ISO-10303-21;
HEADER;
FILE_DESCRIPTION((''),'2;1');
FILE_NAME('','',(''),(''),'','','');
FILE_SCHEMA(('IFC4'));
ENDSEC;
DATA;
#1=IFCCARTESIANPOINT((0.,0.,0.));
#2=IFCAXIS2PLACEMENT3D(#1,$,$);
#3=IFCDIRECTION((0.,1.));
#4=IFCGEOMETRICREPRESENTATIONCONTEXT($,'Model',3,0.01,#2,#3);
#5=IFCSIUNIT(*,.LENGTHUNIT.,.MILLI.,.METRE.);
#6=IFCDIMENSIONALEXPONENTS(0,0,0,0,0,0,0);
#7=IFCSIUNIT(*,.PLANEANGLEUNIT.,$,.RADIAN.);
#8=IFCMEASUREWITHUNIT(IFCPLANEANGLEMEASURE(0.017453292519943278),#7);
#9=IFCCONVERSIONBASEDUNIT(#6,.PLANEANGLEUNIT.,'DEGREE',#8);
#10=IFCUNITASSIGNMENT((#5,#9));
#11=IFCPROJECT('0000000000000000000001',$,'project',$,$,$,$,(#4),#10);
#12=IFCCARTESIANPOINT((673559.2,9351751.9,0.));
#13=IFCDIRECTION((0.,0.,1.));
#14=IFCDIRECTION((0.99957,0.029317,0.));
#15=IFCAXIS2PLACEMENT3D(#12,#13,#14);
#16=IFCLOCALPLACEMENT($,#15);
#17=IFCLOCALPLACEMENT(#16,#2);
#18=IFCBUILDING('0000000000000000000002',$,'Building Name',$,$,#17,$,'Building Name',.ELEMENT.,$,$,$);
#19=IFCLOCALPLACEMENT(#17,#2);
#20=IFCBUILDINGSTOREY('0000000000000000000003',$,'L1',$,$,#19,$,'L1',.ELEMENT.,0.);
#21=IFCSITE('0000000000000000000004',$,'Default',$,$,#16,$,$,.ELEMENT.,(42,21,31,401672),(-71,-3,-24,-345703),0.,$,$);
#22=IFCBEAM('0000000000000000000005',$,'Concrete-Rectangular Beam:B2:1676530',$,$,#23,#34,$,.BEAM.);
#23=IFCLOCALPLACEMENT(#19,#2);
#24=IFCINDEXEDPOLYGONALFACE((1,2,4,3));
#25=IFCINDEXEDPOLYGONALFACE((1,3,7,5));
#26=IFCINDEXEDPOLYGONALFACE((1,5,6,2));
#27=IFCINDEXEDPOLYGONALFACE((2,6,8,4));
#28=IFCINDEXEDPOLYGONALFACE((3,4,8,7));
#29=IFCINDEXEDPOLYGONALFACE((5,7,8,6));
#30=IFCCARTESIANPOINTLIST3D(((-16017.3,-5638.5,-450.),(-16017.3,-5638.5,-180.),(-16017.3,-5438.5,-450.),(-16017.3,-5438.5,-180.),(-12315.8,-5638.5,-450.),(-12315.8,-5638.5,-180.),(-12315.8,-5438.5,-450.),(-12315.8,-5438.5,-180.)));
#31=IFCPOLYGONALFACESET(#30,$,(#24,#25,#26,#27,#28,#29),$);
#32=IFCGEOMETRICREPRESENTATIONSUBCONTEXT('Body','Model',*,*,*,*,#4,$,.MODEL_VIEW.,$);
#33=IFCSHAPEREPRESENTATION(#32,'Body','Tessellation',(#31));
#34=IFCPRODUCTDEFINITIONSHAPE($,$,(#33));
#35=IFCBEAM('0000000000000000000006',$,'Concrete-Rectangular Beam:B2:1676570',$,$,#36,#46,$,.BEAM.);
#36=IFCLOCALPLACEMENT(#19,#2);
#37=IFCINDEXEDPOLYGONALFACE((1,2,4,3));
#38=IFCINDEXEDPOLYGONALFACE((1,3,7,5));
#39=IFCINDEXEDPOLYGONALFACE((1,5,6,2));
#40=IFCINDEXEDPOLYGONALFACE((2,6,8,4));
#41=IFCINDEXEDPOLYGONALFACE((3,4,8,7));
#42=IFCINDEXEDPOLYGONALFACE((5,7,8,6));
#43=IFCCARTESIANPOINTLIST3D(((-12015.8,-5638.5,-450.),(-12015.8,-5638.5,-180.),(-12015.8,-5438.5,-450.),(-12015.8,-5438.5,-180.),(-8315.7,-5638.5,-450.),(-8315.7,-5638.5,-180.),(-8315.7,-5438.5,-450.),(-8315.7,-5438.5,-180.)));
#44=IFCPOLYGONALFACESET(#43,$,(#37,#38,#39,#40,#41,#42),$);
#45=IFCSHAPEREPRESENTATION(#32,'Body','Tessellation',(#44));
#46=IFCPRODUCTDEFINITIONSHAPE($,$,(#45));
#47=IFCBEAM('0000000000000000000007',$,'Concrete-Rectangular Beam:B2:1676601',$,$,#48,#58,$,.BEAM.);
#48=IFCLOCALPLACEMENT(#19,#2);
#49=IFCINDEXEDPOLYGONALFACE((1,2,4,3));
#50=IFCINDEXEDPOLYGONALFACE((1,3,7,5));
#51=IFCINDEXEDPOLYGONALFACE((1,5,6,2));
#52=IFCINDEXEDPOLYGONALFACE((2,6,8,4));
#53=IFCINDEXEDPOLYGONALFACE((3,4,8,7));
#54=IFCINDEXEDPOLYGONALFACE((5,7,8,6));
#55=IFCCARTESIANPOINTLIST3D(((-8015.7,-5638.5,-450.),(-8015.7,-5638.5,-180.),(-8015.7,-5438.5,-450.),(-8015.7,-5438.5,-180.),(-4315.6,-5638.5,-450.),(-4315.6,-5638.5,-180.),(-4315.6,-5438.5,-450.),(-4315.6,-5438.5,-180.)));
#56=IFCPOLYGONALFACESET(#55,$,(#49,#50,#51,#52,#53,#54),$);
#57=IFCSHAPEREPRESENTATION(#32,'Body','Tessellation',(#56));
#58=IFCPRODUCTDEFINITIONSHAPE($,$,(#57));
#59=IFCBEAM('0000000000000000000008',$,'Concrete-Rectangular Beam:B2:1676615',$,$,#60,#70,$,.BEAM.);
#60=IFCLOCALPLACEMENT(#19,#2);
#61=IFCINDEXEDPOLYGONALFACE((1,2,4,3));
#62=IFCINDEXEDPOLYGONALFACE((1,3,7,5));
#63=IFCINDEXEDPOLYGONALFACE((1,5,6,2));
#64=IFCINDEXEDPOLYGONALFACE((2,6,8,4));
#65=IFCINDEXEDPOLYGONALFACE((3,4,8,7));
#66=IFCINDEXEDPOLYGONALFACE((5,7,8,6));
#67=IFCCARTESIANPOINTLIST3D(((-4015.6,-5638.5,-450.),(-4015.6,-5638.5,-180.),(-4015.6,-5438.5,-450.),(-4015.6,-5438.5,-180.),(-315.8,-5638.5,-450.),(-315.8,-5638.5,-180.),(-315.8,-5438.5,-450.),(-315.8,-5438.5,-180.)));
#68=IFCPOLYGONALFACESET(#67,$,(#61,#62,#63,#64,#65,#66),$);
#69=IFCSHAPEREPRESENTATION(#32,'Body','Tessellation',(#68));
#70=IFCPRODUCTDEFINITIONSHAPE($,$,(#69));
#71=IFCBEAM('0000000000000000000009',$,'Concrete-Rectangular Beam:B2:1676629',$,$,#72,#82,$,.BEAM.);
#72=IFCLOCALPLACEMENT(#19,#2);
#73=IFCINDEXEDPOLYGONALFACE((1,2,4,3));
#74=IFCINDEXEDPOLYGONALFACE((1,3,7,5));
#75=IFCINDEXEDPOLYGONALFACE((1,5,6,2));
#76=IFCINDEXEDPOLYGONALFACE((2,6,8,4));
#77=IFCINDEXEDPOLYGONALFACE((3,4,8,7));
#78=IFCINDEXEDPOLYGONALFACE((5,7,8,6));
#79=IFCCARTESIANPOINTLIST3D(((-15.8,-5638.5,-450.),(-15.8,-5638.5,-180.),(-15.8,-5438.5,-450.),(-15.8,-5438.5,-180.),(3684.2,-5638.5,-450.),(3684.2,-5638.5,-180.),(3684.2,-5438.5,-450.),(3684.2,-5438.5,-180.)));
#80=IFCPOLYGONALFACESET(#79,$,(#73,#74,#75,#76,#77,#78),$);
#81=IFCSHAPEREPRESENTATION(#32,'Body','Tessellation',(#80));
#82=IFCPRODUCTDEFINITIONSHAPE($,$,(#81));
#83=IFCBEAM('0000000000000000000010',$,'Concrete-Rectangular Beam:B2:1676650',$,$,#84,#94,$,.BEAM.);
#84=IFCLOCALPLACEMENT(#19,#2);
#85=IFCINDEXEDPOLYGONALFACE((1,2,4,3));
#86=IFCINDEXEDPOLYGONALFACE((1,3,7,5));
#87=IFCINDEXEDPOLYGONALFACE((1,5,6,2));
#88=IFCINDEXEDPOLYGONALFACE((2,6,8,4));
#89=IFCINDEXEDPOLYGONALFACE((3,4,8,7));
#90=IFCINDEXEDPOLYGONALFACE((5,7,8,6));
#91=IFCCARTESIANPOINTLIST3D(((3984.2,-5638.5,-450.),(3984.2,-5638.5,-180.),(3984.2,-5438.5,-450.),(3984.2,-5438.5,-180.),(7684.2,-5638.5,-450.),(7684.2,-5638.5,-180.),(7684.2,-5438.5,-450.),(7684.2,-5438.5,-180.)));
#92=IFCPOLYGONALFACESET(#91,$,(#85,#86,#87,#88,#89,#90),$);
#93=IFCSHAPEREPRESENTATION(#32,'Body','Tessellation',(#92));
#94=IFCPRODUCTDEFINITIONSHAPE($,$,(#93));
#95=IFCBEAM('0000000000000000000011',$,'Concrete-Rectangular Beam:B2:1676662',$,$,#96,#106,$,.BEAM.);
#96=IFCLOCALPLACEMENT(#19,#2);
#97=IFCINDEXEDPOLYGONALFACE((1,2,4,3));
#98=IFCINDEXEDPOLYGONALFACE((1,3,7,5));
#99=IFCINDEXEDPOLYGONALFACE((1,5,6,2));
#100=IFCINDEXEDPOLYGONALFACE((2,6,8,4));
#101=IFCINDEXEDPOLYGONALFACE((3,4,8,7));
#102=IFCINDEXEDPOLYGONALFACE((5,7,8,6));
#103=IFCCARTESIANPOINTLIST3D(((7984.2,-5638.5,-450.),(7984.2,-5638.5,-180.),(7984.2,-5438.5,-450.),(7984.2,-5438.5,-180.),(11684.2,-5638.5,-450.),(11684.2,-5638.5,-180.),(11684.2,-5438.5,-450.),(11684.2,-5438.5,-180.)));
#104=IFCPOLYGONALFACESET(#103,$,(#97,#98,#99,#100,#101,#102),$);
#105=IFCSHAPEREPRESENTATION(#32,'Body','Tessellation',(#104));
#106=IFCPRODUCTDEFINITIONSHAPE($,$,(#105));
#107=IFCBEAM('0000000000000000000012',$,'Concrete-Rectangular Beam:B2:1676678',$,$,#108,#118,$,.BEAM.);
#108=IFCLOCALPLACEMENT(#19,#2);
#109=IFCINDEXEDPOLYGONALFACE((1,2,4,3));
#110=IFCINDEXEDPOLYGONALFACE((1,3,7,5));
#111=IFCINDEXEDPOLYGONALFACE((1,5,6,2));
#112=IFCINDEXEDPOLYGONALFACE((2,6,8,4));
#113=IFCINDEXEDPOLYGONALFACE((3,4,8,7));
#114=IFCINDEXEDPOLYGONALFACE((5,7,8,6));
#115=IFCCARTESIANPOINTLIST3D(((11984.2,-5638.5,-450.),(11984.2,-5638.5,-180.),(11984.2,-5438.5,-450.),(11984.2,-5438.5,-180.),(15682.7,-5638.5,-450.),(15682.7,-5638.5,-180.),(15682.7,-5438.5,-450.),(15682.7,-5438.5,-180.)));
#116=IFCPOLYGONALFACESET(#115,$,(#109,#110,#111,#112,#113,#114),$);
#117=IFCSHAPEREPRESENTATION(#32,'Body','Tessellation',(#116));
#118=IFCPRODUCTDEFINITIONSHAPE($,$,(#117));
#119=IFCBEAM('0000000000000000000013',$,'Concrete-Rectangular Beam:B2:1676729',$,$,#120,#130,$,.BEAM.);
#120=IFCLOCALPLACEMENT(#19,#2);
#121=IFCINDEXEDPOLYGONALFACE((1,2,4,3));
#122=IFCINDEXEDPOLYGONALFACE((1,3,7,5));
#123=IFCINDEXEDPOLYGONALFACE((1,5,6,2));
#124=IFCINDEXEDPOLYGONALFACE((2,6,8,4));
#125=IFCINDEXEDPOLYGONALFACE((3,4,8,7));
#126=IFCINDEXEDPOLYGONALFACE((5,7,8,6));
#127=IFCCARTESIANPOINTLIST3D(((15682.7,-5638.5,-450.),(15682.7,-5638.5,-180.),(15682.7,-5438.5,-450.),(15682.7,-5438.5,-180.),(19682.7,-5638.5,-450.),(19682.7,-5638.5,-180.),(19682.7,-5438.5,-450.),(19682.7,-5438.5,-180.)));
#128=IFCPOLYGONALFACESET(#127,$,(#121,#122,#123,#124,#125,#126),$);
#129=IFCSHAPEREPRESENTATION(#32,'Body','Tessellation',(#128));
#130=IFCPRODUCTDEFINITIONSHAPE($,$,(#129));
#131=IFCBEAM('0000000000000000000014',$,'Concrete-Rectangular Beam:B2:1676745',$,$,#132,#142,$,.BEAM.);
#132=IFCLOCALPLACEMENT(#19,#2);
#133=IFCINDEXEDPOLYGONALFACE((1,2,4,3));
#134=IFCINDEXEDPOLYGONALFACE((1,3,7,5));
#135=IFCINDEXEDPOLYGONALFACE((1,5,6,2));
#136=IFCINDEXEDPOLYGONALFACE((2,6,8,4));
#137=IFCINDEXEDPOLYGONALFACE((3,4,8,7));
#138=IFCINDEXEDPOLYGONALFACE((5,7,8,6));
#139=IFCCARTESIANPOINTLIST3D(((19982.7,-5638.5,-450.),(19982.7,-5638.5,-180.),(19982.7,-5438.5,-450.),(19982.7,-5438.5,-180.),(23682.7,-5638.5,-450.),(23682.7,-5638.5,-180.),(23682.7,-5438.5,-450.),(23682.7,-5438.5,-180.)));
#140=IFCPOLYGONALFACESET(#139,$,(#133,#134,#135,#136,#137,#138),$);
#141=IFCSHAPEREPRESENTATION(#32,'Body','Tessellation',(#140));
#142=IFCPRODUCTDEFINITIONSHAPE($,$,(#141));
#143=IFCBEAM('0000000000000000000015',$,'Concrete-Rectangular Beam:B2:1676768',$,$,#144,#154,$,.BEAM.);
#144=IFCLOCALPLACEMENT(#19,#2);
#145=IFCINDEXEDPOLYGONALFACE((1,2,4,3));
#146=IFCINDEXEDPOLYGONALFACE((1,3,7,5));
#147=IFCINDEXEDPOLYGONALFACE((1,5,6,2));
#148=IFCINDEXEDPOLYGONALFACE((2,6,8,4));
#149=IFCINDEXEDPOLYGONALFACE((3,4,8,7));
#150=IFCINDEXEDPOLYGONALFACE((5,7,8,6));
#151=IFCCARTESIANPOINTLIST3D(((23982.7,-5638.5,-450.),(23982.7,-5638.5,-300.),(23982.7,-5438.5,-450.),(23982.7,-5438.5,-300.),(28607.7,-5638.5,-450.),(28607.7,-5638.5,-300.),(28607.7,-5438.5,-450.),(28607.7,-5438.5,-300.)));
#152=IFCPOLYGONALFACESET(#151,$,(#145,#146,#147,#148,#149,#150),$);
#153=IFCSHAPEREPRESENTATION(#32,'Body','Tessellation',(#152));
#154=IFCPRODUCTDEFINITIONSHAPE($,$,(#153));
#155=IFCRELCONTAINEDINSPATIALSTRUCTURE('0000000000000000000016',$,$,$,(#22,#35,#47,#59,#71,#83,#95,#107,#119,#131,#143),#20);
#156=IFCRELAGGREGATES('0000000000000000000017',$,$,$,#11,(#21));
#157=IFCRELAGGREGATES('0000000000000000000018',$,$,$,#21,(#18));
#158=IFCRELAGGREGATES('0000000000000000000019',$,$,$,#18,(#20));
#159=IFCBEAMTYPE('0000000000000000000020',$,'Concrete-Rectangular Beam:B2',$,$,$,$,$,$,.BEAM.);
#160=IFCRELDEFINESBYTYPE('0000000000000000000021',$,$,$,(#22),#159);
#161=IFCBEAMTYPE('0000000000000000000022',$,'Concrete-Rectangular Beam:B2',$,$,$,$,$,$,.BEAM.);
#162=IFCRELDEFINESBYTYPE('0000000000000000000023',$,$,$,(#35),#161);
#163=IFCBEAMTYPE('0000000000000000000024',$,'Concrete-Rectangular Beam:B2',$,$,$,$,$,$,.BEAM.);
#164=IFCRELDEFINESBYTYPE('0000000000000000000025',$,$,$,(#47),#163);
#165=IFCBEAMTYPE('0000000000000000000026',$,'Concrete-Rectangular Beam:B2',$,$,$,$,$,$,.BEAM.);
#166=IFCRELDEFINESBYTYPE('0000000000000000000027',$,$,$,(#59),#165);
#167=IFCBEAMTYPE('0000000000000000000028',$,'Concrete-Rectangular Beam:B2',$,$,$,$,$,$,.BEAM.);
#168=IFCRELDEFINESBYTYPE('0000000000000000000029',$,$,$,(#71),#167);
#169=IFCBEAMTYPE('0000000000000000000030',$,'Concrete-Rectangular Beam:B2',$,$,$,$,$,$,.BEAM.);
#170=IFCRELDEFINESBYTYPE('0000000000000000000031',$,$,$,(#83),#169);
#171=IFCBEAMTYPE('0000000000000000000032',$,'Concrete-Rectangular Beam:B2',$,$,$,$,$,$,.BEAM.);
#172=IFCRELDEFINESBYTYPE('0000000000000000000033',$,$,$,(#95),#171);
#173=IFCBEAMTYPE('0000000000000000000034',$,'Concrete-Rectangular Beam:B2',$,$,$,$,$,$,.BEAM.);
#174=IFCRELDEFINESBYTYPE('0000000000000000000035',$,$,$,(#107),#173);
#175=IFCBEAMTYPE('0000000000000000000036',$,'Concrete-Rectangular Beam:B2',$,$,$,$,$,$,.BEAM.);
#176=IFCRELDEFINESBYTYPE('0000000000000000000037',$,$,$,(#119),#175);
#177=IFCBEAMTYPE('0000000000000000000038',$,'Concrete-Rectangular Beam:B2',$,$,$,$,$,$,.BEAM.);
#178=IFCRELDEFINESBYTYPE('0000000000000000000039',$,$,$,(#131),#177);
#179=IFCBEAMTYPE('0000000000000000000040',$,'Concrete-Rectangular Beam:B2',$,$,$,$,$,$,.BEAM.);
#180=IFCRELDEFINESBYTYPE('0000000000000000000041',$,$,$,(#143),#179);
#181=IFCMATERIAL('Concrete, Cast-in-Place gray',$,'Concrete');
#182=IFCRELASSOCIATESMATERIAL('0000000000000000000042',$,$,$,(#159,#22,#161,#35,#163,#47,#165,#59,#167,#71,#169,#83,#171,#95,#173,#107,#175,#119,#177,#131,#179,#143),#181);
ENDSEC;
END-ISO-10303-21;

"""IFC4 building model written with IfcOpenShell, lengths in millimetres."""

from ifc_helpers import new_model, entity, si_unit, converted_unit, direction, frame, origin, place, context, subcontext, project, spatial, indexed_curve, outline, extrude, source, transform, mapped, material, type_object, type_shapes, element, save


model = new_model("IFC4")

# Units and contexts
model_context = context("Model", 3, precision=0.01, world=origin(), true_north=direction((0.0, 1.0)))
body_context = subcontext(model_context, "Body", "Model", "MODEL_VIEW")
ifc_project = project(units=[si_unit("LENGTHUNIT", "METRE", prefix="MILLI"), converted_unit("PLANEANGLEUNIT", "DEGREE", entity("IfcPlaneAngleMeasure", 0.017453292519943278), si_unit("PLANEANGLEUNIT", "RADIAN"), dimensions=[0, 0, 0, 0, 0, 0, 0])], contexts=[model_context])

# Site, building, storey
site_placement = place(None, frame((673559.2, 9351751.9, 0.0), z_axis=(0.0, 0.0, 1.0), x_axis=(0.99957, 0.029317, 0.0)))
site = spatial("IfcSite", under=ifc_project, at=site_placement, Name="Default", CompositionType="ELEMENT", RefLatitude=(42, 21, 31, 401672), RefLongitude=(-71, -3, -24, -345703), RefElevation=0.0)
building_placement = place(site_placement, origin())
building = spatial("IfcBuilding", under=site, at=building_placement, Name="Building Name", LongName="Building Name", CompositionType="ELEMENT")
storey_placement = place(building_placement, origin())
storey = spatial("IfcBuildingStorey", under=building, at=storey_placement, Name="L1", LongName="L1", CompositionType="ELEMENT", Elevation=0.0)

# Beams
ifc_material_1 = material(Name="Concrete, Cast-in-Place gray", Category="Concrete")
beam_type_1 = type_object("IfcBeamType", Name="Concrete-Rectangular Beam:B2", PredefinedType="BEAM", material=ifc_material_1)
shared_shape_1 = source(origin(), body_context, "Body", "SweptSolid", [
    extrude(outline(indexed_curve([(-135.0, -100.0), (135.0, -100.0), (135.0, 100.0), (-135.0, 100.0), (-135.0, -100.0)], self_intersect=False)), frame((-16017.3, -5538.5, -315.0), z_axis=(1.0, 0.0, 0.0), x_axis=(0.0, 0.0, -1.0)), (0.0, 0.0, 1.0), 3701.5),
])
type_shapes(beam_type_1, [shared_shape_1])
beam_1_placement = place(storey_placement, origin())
element("IfcBeam", 1, at=beam_1_placement, inside=storey, type_object=beam_type_1, material=ifc_material_1, Name="Concrete-Rectangular Beam:B2:1676530", PredefinedType="BEAM", context=body_context, shape_type="MappedRepresentation", body=[
    mapped(shared_shape_1, transform((0.0, 0.0, 0.0), scale=1.0)),
])
beam_type_2 = type_object("IfcBeamType", Name="Concrete-Rectangular Beam:B2", PredefinedType="BEAM", material=ifc_material_1)
shared_shape_2 = source(origin(), body_context, "Body", "SweptSolid", [
    extrude(outline(indexed_curve([(-135.0, -100.0), (135.0, -100.0), (135.0, 100.0), (-135.0, 100.0), (-135.0, -100.0)], self_intersect=False)), frame((-8315.7, -5538.5, -315.0), z_axis=(-1.0, 0.0, 0.0), x_axis=(0.0, 0.0, -1.0)), (0.0, 0.0, 1.0), 3700.1),
])
type_shapes(beam_type_2, [shared_shape_2])
beam_2_placement = place(storey_placement, origin())
element("IfcBeam", 2, at=beam_2_placement, inside=storey, type_object=beam_type_2, material=ifc_material_1, Name="Concrete-Rectangular Beam:B2:1676570", PredefinedType="BEAM", context=body_context, shape_type="MappedRepresentation", body=[
    mapped(shared_shape_2, transform((0.0, 0.0, 0.0), scale=1.0)),
])
beam_type_3 = type_object("IfcBeamType", Name="Concrete-Rectangular Beam:B2", PredefinedType="BEAM", material=ifc_material_1)
shared_shape_3 = source(origin(), body_context, "Body", "SweptSolid", [
    extrude(outline(indexed_curve([(-135.0, -100.0), (135.0, -100.0), (135.0, 100.0), (-135.0, 100.0), (-135.0, -100.0)], self_intersect=False)), frame((-8015.7, -5538.5, -315.0), z_axis=(1.0, 0.0, 0.0), x_axis=(0.0, 0.0, -1.0)), (0.0, 0.0, 1.0), 3700.1),
])
type_shapes(beam_type_3, [shared_shape_3])
beam_3_placement = place(storey_placement, origin())
element("IfcBeam", 3, at=beam_3_placement, inside=storey, type_object=beam_type_3, material=ifc_material_1, Name="Concrete-Rectangular Beam:B2:1676601", PredefinedType="BEAM", context=body_context, shape_type="MappedRepresentation", body=[
    mapped(shared_shape_3, transform((0.0, 0.0, 0.0), scale=1.0)),
])
beam_type_4 = type_object("IfcBeamType", Name="Concrete-Rectangular Beam:B2", PredefinedType="BEAM", material=ifc_material_1)
shared_shape_4 = source(origin(), body_context, "Body", "SweptSolid", [
    extrude(outline(indexed_curve([(-135.0, -100.0), (135.0, -100.0), (135.0, 100.0), (-135.0, 100.0), (-135.0, -100.0)], self_intersect=False)), frame((-4015.6, -5538.5, -315.0), z_axis=(1.0, 0.0, 0.0), x_axis=(0.0, 0.0, -1.0)), (0.0, 0.0, 1.0), 3699.7),
])
type_shapes(beam_type_4, [shared_shape_4])
beam_4_placement = place(storey_placement, origin())
element("IfcBeam", 4, at=beam_4_placement, inside=storey, type_object=beam_type_4, material=ifc_material_1, Name="Concrete-Rectangular Beam:B2:1676615", PredefinedType="BEAM", context=body_context, shape_type="MappedRepresentation", body=[
    mapped(shared_shape_4, transform((0.0, 0.0, 0.0), scale=1.0)),
])
beam_type_5 = type_object("IfcBeamType", Name="Concrete-Rectangular Beam:B2", PredefinedType="BEAM", material=ifc_material_1)
shared_shape_5 = source(origin(), body_context, "Body", "SweptSolid", [
    extrude(outline(indexed_curve([(-135.0, -100.0), (135.0, -100.0), (135.0, 100.0), (-135.0, 100.0), (-135.0, -100.0)], self_intersect=False)), frame((-15.8, -5538.5, -315.0), z_axis=(1.0, 0.0, 0.0), x_axis=(0.0, 0.0, -1.0)), (0.0, 0.0, 1.0), 3700.0),
])
type_shapes(beam_type_5, [shared_shape_5])
beam_5_placement = place(storey_placement, origin())
element("IfcBeam", 5, at=beam_5_placement, inside=storey, type_object=beam_type_5, material=ifc_material_1, Name="Concrete-Rectangular Beam:B2:1676629", PredefinedType="BEAM", context=body_context, shape_type="MappedRepresentation", body=[
    mapped(shared_shape_5, transform((0.0, 0.0, 0.0), scale=1.0)),
])
beam_type_6 = type_object("IfcBeamType", Name="Concrete-Rectangular Beam:B2", PredefinedType="BEAM", material=ifc_material_1)
shared_shape_6 = source(origin(), body_context, "Body", "SweptSolid", [
    extrude(outline(indexed_curve([(-135.0, -100.0), (135.0, -100.0), (135.0, 100.0), (-135.0, 100.0), (-135.0, -100.0)], self_intersect=False)), frame((3984.2, -5538.5, -315.0), z_axis=(1.0, 0.0, 0.0), x_axis=(0.0, 0.0, -1.0)), (0.0, 0.0, 1.0), 3700.0),
])
type_shapes(beam_type_6, [shared_shape_6])
beam_6_placement = place(storey_placement, origin())
element("IfcBeam", 6, at=beam_6_placement, inside=storey, type_object=beam_type_6, material=ifc_material_1, Name="Concrete-Rectangular Beam:B2:1676650", PredefinedType="BEAM", context=body_context, shape_type="MappedRepresentation", body=[
    mapped(shared_shape_6, transform((0.0, 0.0, 0.0), scale=1.0)),
])
beam_type_7 = type_object("IfcBeamType", Name="Concrete-Rectangular Beam:B2", PredefinedType="BEAM", material=ifc_material_1)
shared_shape_7 = source(origin(), body_context, "Body", "SweptSolid", [
    extrude(outline(indexed_curve([(-135.0, -100.0), (135.0, -100.0), (135.0, 100.0), (-135.0, 100.0), (-135.0, -100.0)], self_intersect=False)), frame((7984.2, -5538.5, -315.0), z_axis=(1.0, 0.0, 0.0), x_axis=(0.0, 0.0, -1.0)), (0.0, 0.0, 1.0), 3700.0),
])
type_shapes(beam_type_7, [shared_shape_7])
beam_7_placement = place(storey_placement, origin())
element("IfcBeam", 7, at=beam_7_placement, inside=storey, type_object=beam_type_7, material=ifc_material_1, Name="Concrete-Rectangular Beam:B2:1676662", PredefinedType="BEAM", context=body_context, shape_type="MappedRepresentation", body=[
    mapped(shared_shape_7, transform((0.0, 0.0, 0.0), scale=1.0)),
])
beam_type_8 = type_object("IfcBeamType", Name="Concrete-Rectangular Beam:B2", PredefinedType="BEAM", material=ifc_material_1)
shared_shape_8 = source(origin(), body_context, "Body", "SweptSolid", [
    extrude(outline(indexed_curve([(-135.0, -100.0), (135.0, -100.0), (135.0, 100.0), (-135.0, 100.0), (-135.0, -100.0)], self_intersect=False)), frame((11984.2, -5538.5, -315.0), z_axis=(1.0, 0.0, 0.0), x_axis=(0.0, 0.0, -1.0)), (0.0, 0.0, 1.0), 3698.5),
])
type_shapes(beam_type_8, [shared_shape_8])
beam_8_placement = place(storey_placement, origin())
element("IfcBeam", 8, at=beam_8_placement, inside=storey, type_object=beam_type_8, material=ifc_material_1, Name="Concrete-Rectangular Beam:B2:1676678", PredefinedType="BEAM", context=body_context, shape_type="MappedRepresentation", body=[
    mapped(shared_shape_8, transform((0.0, 0.0, 0.0), scale=1.0)),
])
beam_type_9 = type_object("IfcBeamType", Name="Concrete-Rectangular Beam:B2", PredefinedType="BEAM", material=ifc_material_1)
shared_shape_9 = source(origin(), body_context, "Body", "SweptSolid", [
    extrude(outline(indexed_curve([(-135.0, -100.0), (135.0, -100.0), (135.0, 100.0), (-135.0, 100.0), (-135.0, -100.0)], self_intersect=False)), frame((15682.7, -5538.5, -315.0), z_axis=(1.0, 0.0, 0.0), x_axis=(0.0, 0.0, -1.0)), (0.0, 0.0, 1.0), 4000.0),
])
type_shapes(beam_type_9, [shared_shape_9])
beam_9_placement = place(storey_placement, origin())
element("IfcBeam", 9, at=beam_9_placement, inside=storey, type_object=beam_type_9, material=ifc_material_1, Name="Concrete-Rectangular Beam:B2:1676729", PredefinedType="BEAM", context=body_context, shape_type="MappedRepresentation", body=[
    mapped(shared_shape_9, transform((0.0, 0.0, 0.0), scale=1.0)),
])
beam_type_10 = type_object("IfcBeamType", Name="Concrete-Rectangular Beam:B2", PredefinedType="BEAM", material=ifc_material_1)
shared_shape_10 = source(origin(), body_context, "Body", "SweptSolid", [
    extrude(outline(indexed_curve([(-135.0, -100.0), (135.0, -100.0), (135.0, 100.0), (-135.0, 100.0), (-135.0, -100.0)], self_intersect=False)), frame((19982.7, -5538.5, -315.0), z_axis=(1.0, 0.0, 0.0), x_axis=(0.0, 0.0, -1.0)), (0.0, 0.0, 1.0), 3700.0),
])
type_shapes(beam_type_10, [shared_shape_10])
beam_10_placement = place(storey_placement, origin())
element("IfcBeam", 10, at=beam_10_placement, inside=storey, type_object=beam_type_10, material=ifc_material_1, Name="Concrete-Rectangular Beam:B2:1676745", PredefinedType="BEAM", context=body_context, shape_type="MappedRepresentation", body=[
    mapped(shared_shape_10, transform((0.0, 0.0, 0.0), scale=1.0)),
])
beam_type_11 = type_object("IfcBeamType", Name="Concrete-Rectangular Beam:B2", PredefinedType="BEAM", material=ifc_material_1)
shared_shape_11 = source(origin(), body_context, "Body", "SweptSolid", [
    extrude(outline(indexed_curve([(-75.0, -100.0), (75.0, -100.0), (75.0, 100.0), (-75.0, 100.0), (-75.0, -100.0)], self_intersect=False)), frame((23982.7, -5538.5, -375.0), z_axis=(1.0, 0.0, 0.0), x_axis=(0.0, 0.0, -1.0)), (0.0, 0.0, 1.0), 4625.0),
])
type_shapes(beam_type_11, [shared_shape_11])
beam_11_placement = place(storey_placement, origin())
element("IfcBeam", 11, at=beam_11_placement, inside=storey, type_object=beam_type_11, material=ifc_material_1, Name="Concrete-Rectangular Beam:B2:1676768", PredefinedType="BEAM", context=body_context, shape_type="MappedRepresentation", body=[
    mapped(shared_shape_11, transform((0.0, 0.0, 0.0), scale=1.0)),
])

save(model, "model.ifc")
